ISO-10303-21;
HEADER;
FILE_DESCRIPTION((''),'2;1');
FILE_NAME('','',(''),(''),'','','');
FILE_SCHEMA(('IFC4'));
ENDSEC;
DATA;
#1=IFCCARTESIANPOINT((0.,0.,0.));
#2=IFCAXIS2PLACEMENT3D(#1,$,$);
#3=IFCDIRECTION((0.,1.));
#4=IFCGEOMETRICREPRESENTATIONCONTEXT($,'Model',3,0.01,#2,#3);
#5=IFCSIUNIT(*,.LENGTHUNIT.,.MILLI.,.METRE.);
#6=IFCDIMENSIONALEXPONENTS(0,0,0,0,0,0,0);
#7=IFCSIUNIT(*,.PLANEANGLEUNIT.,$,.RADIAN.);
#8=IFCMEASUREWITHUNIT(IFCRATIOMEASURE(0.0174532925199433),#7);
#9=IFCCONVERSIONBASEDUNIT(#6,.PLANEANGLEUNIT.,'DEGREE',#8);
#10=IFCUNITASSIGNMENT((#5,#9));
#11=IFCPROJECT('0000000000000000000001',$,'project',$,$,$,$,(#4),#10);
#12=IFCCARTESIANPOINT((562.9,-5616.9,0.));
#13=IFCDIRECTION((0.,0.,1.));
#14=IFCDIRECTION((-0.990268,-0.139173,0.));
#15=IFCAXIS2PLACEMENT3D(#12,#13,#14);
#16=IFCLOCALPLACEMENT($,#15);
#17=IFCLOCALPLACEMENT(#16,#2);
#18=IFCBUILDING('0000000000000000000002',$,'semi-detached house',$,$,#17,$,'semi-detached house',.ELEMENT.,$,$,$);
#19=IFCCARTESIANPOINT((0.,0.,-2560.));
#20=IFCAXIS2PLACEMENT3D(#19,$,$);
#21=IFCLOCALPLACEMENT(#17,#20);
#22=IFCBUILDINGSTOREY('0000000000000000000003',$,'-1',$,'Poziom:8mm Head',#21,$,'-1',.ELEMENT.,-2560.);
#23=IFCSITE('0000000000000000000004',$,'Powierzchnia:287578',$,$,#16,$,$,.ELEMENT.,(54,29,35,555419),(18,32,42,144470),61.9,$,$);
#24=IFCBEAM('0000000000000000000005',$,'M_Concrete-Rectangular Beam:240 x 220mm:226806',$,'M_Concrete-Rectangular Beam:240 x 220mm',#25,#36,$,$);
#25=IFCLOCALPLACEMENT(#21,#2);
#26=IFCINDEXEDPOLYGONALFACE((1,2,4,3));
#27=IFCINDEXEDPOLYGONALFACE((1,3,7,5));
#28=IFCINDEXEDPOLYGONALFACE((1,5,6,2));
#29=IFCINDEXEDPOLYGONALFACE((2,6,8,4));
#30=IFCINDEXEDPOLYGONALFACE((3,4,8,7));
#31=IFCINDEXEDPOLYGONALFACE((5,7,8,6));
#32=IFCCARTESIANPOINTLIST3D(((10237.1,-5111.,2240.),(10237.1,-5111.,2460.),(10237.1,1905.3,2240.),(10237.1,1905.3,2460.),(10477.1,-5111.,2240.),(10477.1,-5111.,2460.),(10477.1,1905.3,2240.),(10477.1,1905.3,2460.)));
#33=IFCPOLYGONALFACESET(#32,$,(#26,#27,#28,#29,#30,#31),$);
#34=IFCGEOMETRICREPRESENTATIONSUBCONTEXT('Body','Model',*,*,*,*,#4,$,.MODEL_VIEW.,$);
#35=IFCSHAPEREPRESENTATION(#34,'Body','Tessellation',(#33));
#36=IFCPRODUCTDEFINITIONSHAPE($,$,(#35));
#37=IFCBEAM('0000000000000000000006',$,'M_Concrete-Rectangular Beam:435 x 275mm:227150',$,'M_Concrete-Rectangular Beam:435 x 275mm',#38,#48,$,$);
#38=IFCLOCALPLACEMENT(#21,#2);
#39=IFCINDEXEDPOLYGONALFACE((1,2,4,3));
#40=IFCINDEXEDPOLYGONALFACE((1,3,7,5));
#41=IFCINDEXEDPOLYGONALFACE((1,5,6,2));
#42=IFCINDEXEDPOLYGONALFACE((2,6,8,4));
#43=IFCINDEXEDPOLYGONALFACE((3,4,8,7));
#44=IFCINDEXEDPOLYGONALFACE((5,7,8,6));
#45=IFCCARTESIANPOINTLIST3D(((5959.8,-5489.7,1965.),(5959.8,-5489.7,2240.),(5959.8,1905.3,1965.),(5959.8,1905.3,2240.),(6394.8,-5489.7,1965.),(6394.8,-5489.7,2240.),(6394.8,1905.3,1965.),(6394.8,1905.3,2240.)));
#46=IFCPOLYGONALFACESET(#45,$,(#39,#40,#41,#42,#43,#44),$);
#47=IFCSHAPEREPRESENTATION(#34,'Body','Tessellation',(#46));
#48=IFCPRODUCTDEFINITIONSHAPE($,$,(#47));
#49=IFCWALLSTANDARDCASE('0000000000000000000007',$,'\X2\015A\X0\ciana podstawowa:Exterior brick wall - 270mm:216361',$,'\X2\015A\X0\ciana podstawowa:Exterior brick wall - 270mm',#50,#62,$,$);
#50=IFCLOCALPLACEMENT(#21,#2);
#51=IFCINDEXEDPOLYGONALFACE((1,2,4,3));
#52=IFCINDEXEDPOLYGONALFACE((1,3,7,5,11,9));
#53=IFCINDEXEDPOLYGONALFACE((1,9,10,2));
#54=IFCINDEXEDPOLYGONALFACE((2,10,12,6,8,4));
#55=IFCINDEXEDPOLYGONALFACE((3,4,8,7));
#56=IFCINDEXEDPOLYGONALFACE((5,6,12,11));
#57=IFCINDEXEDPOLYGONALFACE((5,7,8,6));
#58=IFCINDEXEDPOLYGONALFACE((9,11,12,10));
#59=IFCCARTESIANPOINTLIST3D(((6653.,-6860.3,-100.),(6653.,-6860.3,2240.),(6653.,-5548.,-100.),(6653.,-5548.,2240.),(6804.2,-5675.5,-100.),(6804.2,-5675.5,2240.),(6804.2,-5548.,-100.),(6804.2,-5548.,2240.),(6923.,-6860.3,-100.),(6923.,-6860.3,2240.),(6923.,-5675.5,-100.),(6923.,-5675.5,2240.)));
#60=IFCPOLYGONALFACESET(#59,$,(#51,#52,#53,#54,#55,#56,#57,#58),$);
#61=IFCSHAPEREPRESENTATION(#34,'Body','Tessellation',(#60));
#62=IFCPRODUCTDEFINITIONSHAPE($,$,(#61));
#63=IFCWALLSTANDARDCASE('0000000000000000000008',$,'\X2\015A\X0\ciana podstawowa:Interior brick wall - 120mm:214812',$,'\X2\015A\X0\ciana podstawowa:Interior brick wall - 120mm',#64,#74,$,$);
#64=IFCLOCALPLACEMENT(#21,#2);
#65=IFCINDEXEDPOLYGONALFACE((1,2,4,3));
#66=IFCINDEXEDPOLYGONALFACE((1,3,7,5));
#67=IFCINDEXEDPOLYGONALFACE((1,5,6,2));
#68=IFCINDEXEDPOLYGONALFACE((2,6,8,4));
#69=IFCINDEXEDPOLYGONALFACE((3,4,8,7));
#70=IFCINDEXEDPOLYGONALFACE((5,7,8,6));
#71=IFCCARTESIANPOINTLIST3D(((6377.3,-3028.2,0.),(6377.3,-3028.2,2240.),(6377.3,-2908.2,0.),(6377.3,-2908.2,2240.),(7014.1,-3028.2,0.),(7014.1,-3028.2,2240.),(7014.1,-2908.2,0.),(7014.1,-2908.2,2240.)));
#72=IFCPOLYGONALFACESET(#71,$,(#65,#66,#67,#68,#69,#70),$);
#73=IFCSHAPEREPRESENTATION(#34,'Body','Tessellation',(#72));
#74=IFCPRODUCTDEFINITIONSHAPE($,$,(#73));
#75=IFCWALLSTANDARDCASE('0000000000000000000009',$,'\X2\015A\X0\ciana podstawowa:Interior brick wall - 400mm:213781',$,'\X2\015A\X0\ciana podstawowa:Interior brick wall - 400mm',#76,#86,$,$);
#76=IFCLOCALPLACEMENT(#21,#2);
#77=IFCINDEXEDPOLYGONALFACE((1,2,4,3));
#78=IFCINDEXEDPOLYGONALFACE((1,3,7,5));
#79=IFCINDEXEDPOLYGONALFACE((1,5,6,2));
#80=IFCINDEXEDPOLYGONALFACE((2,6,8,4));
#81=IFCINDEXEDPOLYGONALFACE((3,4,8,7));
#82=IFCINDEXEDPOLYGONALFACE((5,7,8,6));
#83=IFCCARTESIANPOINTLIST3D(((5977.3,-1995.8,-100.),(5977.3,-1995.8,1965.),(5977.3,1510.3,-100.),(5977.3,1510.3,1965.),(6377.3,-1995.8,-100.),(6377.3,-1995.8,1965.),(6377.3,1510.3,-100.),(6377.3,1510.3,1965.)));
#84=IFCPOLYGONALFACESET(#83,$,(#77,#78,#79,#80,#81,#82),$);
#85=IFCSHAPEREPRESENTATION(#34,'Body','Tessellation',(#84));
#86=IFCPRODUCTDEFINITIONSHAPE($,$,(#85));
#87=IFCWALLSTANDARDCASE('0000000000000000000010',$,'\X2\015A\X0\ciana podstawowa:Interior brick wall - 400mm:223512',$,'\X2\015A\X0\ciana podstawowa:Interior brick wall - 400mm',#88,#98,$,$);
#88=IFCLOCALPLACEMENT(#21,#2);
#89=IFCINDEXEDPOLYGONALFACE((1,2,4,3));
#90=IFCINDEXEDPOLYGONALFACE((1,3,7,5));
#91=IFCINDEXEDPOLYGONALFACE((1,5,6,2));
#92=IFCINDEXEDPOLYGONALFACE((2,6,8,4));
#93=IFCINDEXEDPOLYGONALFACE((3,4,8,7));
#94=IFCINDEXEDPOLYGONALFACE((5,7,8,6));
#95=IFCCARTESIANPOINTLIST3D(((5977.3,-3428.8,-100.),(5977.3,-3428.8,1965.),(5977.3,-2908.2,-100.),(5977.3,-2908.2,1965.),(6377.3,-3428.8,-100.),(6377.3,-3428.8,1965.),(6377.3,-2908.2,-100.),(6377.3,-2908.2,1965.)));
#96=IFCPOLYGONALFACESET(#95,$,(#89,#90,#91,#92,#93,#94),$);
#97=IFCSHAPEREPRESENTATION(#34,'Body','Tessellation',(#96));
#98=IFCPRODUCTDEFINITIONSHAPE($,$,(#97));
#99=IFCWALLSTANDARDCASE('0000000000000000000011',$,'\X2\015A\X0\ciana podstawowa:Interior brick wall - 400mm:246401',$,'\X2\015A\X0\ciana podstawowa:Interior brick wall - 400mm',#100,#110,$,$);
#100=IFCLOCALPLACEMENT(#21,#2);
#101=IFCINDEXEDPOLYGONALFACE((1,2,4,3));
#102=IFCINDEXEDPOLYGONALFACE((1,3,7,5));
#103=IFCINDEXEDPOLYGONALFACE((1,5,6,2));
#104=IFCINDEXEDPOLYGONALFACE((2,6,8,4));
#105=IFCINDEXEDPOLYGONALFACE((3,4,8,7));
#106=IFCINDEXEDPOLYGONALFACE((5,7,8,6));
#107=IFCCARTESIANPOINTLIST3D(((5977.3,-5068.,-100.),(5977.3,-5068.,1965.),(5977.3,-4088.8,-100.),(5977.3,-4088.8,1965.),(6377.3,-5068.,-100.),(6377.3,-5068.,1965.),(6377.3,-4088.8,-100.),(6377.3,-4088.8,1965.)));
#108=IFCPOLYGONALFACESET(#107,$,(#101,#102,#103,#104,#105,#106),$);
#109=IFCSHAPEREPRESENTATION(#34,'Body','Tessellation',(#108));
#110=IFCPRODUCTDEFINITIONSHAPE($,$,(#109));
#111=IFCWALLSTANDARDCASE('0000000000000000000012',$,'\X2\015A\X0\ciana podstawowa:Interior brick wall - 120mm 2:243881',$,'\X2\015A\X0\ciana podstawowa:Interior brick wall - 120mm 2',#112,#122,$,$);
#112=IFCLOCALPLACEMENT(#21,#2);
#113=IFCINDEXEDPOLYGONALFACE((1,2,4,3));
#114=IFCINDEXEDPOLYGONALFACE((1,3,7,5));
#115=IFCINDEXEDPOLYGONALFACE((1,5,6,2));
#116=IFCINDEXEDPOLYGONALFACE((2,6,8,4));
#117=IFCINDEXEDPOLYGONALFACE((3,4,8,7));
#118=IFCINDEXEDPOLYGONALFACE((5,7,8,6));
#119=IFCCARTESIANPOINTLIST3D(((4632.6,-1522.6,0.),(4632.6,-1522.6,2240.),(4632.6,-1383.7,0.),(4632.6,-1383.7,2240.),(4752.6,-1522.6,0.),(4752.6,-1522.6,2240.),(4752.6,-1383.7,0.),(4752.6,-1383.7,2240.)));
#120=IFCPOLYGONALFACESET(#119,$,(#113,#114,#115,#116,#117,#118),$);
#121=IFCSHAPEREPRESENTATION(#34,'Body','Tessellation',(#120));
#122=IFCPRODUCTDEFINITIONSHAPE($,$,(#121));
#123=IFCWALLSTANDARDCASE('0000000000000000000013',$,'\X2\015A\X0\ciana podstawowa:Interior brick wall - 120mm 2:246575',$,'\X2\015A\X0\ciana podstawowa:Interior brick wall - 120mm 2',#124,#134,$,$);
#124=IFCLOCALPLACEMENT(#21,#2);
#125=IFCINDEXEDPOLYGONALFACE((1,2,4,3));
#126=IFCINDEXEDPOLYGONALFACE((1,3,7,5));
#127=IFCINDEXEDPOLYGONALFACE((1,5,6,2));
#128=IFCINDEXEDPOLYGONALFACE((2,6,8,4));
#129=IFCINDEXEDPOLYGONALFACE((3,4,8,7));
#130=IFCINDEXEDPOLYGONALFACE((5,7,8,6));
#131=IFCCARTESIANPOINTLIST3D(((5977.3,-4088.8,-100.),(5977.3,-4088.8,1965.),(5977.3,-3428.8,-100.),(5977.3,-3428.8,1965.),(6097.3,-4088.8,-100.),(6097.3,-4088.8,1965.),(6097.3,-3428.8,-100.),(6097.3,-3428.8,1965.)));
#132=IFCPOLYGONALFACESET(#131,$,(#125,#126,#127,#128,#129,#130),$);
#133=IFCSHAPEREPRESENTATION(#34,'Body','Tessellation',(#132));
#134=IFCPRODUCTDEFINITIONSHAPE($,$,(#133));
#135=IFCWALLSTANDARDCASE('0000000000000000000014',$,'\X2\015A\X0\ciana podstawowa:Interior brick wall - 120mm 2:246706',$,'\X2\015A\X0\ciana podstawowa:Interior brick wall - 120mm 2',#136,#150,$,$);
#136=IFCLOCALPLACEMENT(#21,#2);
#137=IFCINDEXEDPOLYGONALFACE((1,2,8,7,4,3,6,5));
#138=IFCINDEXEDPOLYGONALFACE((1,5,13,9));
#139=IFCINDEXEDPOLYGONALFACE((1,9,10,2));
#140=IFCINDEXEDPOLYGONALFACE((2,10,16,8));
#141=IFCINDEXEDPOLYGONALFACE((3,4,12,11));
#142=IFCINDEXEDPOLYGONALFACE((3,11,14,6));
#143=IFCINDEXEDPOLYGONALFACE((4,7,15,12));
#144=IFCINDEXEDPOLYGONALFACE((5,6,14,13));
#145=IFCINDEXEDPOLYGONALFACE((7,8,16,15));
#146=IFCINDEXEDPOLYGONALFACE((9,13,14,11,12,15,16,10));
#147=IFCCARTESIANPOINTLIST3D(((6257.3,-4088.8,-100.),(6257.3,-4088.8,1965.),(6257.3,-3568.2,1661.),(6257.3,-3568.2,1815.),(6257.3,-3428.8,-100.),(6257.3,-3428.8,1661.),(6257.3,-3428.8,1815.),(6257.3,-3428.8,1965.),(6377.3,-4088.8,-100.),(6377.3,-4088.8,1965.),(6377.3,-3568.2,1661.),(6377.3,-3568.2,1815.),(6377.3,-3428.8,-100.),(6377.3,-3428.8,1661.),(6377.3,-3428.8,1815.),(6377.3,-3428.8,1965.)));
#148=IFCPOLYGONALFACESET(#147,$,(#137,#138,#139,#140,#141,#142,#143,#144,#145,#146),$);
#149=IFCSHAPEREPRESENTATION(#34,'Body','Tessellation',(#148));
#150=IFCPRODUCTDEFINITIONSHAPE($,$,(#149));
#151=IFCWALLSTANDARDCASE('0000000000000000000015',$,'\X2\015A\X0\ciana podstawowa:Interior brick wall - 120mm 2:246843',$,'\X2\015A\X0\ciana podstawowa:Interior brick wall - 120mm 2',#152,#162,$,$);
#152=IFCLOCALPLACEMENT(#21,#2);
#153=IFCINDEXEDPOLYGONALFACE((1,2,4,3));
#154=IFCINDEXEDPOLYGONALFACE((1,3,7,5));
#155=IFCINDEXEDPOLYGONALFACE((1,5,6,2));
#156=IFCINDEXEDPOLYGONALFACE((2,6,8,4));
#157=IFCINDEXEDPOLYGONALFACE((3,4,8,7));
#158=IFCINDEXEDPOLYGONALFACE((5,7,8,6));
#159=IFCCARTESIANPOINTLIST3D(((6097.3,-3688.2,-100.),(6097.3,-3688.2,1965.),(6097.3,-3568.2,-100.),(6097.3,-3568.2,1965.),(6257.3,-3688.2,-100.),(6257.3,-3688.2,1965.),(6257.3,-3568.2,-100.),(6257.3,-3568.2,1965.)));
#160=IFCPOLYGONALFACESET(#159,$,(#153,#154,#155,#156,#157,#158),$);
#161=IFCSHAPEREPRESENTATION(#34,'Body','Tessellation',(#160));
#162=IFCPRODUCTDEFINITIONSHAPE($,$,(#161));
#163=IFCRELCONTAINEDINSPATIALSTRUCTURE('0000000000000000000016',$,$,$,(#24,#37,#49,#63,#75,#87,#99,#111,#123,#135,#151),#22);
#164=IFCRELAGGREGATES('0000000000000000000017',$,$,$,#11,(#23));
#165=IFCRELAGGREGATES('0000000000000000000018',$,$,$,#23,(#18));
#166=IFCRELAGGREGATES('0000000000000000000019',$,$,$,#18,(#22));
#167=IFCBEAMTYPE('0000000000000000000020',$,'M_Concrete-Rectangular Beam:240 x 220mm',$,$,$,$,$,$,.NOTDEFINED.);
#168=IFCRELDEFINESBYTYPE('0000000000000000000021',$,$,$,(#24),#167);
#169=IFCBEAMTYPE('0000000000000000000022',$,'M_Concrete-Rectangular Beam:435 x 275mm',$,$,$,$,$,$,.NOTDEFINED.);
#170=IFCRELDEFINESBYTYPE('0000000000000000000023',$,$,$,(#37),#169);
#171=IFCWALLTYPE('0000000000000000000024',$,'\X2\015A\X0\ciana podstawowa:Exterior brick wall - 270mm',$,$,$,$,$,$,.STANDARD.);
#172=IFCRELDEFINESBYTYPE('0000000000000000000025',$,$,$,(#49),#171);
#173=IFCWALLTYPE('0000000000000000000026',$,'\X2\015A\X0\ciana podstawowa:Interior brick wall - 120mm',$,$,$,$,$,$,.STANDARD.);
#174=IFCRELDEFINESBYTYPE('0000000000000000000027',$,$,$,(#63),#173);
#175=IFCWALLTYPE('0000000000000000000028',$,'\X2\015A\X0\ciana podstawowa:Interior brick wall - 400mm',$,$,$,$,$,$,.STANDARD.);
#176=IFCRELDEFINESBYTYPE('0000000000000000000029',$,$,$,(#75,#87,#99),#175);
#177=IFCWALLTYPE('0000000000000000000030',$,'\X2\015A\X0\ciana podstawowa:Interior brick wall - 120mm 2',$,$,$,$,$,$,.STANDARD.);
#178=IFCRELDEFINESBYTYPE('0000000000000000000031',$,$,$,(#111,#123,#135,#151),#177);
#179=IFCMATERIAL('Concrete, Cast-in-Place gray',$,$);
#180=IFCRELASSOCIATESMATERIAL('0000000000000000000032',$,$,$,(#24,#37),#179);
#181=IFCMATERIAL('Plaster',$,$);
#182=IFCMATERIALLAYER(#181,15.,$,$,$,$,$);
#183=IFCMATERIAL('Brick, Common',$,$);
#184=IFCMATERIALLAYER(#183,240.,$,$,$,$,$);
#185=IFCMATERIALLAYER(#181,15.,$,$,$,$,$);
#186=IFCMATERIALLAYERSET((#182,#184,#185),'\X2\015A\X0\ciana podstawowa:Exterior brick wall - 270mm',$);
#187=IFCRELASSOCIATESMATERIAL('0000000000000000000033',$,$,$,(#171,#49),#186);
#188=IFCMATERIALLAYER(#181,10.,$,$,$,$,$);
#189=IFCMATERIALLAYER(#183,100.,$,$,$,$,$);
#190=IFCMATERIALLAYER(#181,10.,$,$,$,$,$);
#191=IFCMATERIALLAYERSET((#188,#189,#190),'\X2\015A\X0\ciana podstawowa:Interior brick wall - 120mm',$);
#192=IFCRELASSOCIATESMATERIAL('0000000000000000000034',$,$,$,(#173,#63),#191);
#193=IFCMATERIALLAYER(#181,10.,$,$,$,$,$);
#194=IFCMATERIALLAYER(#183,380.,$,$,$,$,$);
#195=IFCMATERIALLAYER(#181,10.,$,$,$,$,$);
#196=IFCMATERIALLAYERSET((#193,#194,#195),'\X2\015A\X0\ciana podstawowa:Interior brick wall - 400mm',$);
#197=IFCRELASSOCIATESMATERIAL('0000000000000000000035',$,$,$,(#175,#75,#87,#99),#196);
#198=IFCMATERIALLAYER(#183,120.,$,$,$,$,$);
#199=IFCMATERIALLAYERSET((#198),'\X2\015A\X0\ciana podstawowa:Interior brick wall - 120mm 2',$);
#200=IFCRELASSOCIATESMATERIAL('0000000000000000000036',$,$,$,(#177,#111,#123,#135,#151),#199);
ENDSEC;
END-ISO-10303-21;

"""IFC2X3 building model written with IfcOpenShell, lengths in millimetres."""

from ifc_helpers import new_model, entity, si_unit, converted_unit, direction, frame, frame_2d, origin, place, context, subcontext, project, spatial, polyline, rectangle, outline, extrude, clip, bounded_halfspace, material, layer, layer_set, layer_usage, type_object, element, save


model = new_model("IFC2X3")

# Units and contexts
model_context = context("Model", 3, precision=0.01, world=origin(), true_north=direction((0.0, 1.0)))
body_context = subcontext(model_context, "Body", "Model", "MODEL_VIEW")
ifc_project = project(units=[si_unit("LENGTHUNIT", "METRE", prefix="MILLI"), converted_unit("PLANEANGLEUNIT", "DEGREE", entity("IfcRatioMeasure", 0.0174532925199433), si_unit("PLANEANGLEUNIT", "RADIAN"), dimensions=[0, 0, 0, 0, 0, 0, 0])], contexts=[model_context])

# Site, building, storey
site_placement = place(None, frame((562.9, -5616.9, 0.0), z_axis=(0.0, 0.0, 1.0), x_axis=(-0.990268, -0.139173, 0.0)))
site = spatial("IfcSite", under=ifc_project, at=site_placement, Name="Powierzchnia:287578", CompositionType="ELEMENT", RefLatitude=(54, 29, 35, 555419), RefLongitude=(18, 32, 42, 144470), RefElevation=61.9)
building_placement = place(site_placement, origin())
building = spatial("IfcBuilding", under=site, at=building_placement, Name="semi-detached house", LongName="semi-detached house", CompositionType="ELEMENT")
storey_placement = place(building_placement, frame((0.0, 0.0, -2560.0)))
storey = spatial("IfcBuildingStorey", under=building, at=storey_placement, Name="-1", ObjectType="Poziom:8mm Head", LongName="-1", CompositionType="ELEMENT", Elevation=-2560.0)

# Beams
ifc_material_1 = material(Name="Concrete, Cast-in-Place gray")
beam_type_1 = type_object("IfcBeamType", Name="M_Concrete-Rectangular Beam:240 x 220mm", PredefinedType="NOTDEFINED")
beam_1_placement = place(storey_placement, frame((10357.1, 1905.3, 2460.0), z_axis=(0.0, 0.0, 1.0), x_axis=(0.0, -1.0, 0.0)))
element("IfcBeam", 1, at=beam_1_placement, inside=storey, type_object=beam_type_1, material=ifc_material_1, Name="M_Concrete-Rectangular Beam:240 x 220mm:226806", ObjectType="M_Concrete-Rectangular Beam:240 x 220mm", context=body_context, shape_type="SweptSolid", body=[
    extrude(rectangle(XDim=220.0, YDim=240.0, at=frame_2d((0.0, 0.0), x_axis=(1.0, 0.0))), frame((0.0, 0.0, -110.0), z_axis=(1.0, 0.0, 0.0), x_axis=(0.0, 0.0, -1.0)), (0.0, 0.0, 1.0), 7016.3),
])
beam_type_2 = type_object("IfcBeamType", Name="M_Concrete-Rectangular Beam:435 x 275mm", PredefinedType="NOTDEFINED")
beam_2_placement = place(storey_placement, frame((6177.3, 1905.3, 2240.0), z_axis=(0.0, 0.0, 1.0), x_axis=(0.0, -1.0, 0.0)))
element("IfcBeam", 2, at=beam_2_placement, inside=storey, type_object=beam_type_2, material=ifc_material_1, Name="M_Concrete-Rectangular Beam:435 x 275mm:227150", ObjectType="M_Concrete-Rectangular Beam:435 x 275mm", context=body_context, shape_type="SweptSolid", body=[
    extrude(rectangle(XDim=275.0, YDim=435.0, at=frame_2d((0.0, 0.0), x_axis=(1.0, 0.0))), frame((0.0, 0.0, -137.5), z_axis=(1.0, 0.0, 0.0), x_axis=(0.0, 0.0, -1.0)), (0.0, 0.0, 1.0), 7395.0),
])

# Walls
ifc_material_2 = material(Name="Plaster")
ifc_layer_1 = layer(ifc_material_2, 15.0)
ifc_material_3 = material(Name="Brick, Common")
ifc_layer_2 = layer(ifc_material_3, 240.0)
ifc_layer_3 = layer(ifc_material_2, 15.0)
ifc_layer_set_1 = layer_set([ifc_layer_1, ifc_layer_2, ifc_layer_3], Name="Ściana podstawowa:Exterior brick wall - 270mm")
ifc_layer_usage_1 = layer_usage(ifc_layer_set_1, "AXIS2", "POSITIVE", -135.0)
wall_type_1 = type_object("IfcWallType", Name="Ściana podstawowa:Exterior brick wall - 270mm", PredefinedType="STANDARD", material=ifc_layer_set_1)
wall_1_placement = place(storey_placement, frame((6788.0, -6860.3, -100.0), z_axis=(0.0, 0.0, 1.0), x_axis=(0.0, 1.0, 0.0)))
element("IfcWallStandardCase", 3, at=wall_1_placement, inside=storey, type_object=wall_type_1, material=ifc_layer_usage_1, Name="Ściana podstawowa:Exterior brick wall - 270mm:216361", ObjectType="Ściana podstawowa:Exterior brick wall - 270mm", context=body_context, shape_type="Clipping", body=[
    clip(extrude(outline(polyline([(1184.7, -135.0), (1184.7, -16.1), (1286.0, -16.1), (1312.2, -16.1), (1312.2, 135.0), (0.0, 135.0), (0.0, -135.0), (1184.7, -135.0)])), origin(), (0.0, 0.0, 1.0), 2340.0), bounded_halfspace(frame((0.0, -135.0, 2340.0), z_axis=(0.0, 0.0, -1.0), x_axis=(1.0, 0.0, 0.0)), True, frame((0.0, -135.0, 2340.0)), polyline([(0.0, 0.0), (1184.7, 0.0), (1184.7, 118.9), (1312.2, 118.9), (1312.2, 270.0), (0.0, 270.0), (0.0, 0.0)]))),
])
ifc_layer_4 = layer(ifc_material_2, 10.0)
ifc_layer_5 = layer(ifc_material_3, 100.0)
ifc_layer_6 = layer(ifc_material_2, 10.0)
ifc_layer_set_2 = layer_set([ifc_layer_4, ifc_layer_5, ifc_layer_6], Name="Ściana podstawowa:Interior brick wall - 120mm")
ifc_layer_usage_2 = layer_usage(ifc_layer_set_2, "AXIS2", "POSITIVE", -60.0)
wall_type_2 = type_object("IfcWallType", Name="Ściana podstawowa:Interior brick wall - 120mm", PredefinedType="STANDARD", material=ifc_layer_set_2)
wall_2_placement = place(storey_placement, frame((6377.3, -2968.2, 0.0)))
element("IfcWallStandardCase", 4, at=wall_2_placement, inside=storey, type_object=wall_type_2, material=ifc_layer_usage_2, Name="Ściana podstawowa:Interior brick wall - 120mm:214812", ObjectType="Ściana podstawowa:Interior brick wall - 120mm", context=body_context, shape_type="Clipping", body=[
    clip(extrude(rectangle(XDim=636.8, YDim=120.0, at=frame_2d((318.4, 0.0), x_axis=(-1.0, 0.0))), origin(), (0.0, 0.0, 1.0), 2240.0), bounded_halfspace(frame((636.8, -60.0, 0.0), z_axis=(0.0, 0.0, 1.0), x_axis=(0.0, 1.0, 0.0)), True, frame((636.8, -60.0, 0.0), z_axis=(0.0, 0.0, 1.0), x_axis=(0.0, 1.0, 0.0)), polyline([(0.0, 0.0), (120.0, 0.0), (120.0, 636.8), (0.0, 636.8), (0.0, 0.0)]))),
])
ifc_layer_7 = layer(ifc_material_2, 10.0)
ifc_layer_8 = layer(ifc_material_3, 380.0)
ifc_layer_9 = layer(ifc_material_2, 10.0)
ifc_layer_set_3 = layer_set([ifc_layer_7, ifc_layer_8, ifc_layer_9], Name="Ściana podstawowa:Interior brick wall - 400mm")
wall_type_3 = type_object("IfcWallType", Name="Ściana podstawowa:Interior brick wall - 400mm", PredefinedType="STANDARD", material=ifc_layer_set_3)
ifc_layer_usage_3 = layer_usage(ifc_layer_set_3, "AXIS2", "NEGATIVE", 200.0)
wall_3_placement = place(storey_placement, frame((6177.3, 1510.3, -100.0), z_axis=(0.0, 0.0, 1.0), x_axis=(0.0, -1.0, 0.0)))
element("IfcWallStandardCase", 5, at=wall_3_placement, inside=storey, type_object=wall_type_3, material=ifc_layer_usage_3, Name="Ściana podstawowa:Interior brick wall - 400mm:213781", ObjectType="Ściana podstawowa:Interior brick wall - 400mm", context=body_context, shape_type="SweptSolid", body=[
    extrude(rectangle(XDim=3506.1, YDim=400.0, at=frame_2d((1753.1, 0.0), x_axis=(-1.0, 0.0))), origin(), (0.0, 0.0, 1.0), 2065.0),
])
ifc_layer_usage_4 = layer_usage(ifc_layer_set_3, "AXIS2", "NEGATIVE", 200.0)
wall_4_placement = place(storey_placement, frame((6177.3, -2908.2, -100.0), z_axis=(0.0, 0.0, 1.0), x_axis=(0.0, -1.0, 0.0)))
element("IfcWallStandardCase", 6, at=wall_4_placement, inside=storey, type_object=wall_type_3, material=ifc_layer_usage_4, Name="Ściana podstawowa:Interior brick wall - 400mm:223512", ObjectType="Ściana podstawowa:Interior brick wall - 400mm", context=body_context, shape_type="SweptSolid", body=[
    extrude(rectangle(XDim=520.6, YDim=400.0, at=frame_2d((260.3, 0.0), x_axis=(-1.0, 0.0))), origin(), (0.0, 0.0, 1.0), 2065.0),
])
ifc_layer_usage_5 = layer_usage(ifc_layer_set_3, "AXIS2", "NEGATIVE", 200.0)
wall_5_placement = place(storey_placement, frame((6177.3, -4088.8, -100.0), z_axis=(0.0, 0.0, 1.0), x_axis=(0.0, -1.0, 0.0)))
element("IfcWallStandardCase", 7, at=wall_5_placement, inside=storey, type_object=wall_type_3, material=ifc_layer_usage_5, Name="Ściana podstawowa:Interior brick wall - 400mm:246401", ObjectType="Ściana podstawowa:Interior brick wall - 400mm", context=body_context, shape_type="SweptSolid", body=[
    extrude(rectangle(XDim=979.2, YDim=400.0, at=frame_2d((489.6, 0.0), x_axis=(-1.0, 0.0))), origin(), (0.0, 0.0, 1.0), 2065.0),
])
ifc_layer_10 = layer(ifc_material_3, 120.0)
ifc_layer_set_4 = layer_set([ifc_layer_10], Name="Ściana podstawowa:Interior brick wall - 120mm 2")
ifc_layer_usage_6 = layer_usage(ifc_layer_set_4, "AXIS2", "NEGATIVE", 60.0)
wall_type_4 = type_object("IfcWallType", Name="Ściana podstawowa:Interior brick wall - 120mm 2", PredefinedType="STANDARD", material=ifc_layer_set_4)
wall_6_placement = place(storey_placement, frame((4692.6, -1522.6, 0.0), z_axis=(0.0, 0.0, 1.0), x_axis=(0.0, 1.0, 0.0)))
element("IfcWallStandardCase", 8, at=wall_6_placement, inside=storey, type_object=wall_type_4, material=ifc_layer_usage_6, Name="Ściana podstawowa:Interior brick wall - 120mm 2:243881", ObjectType="Ściana podstawowa:Interior brick wall - 120mm 2", context=body_context, shape_type="Clipping", body=[
    clip(extrude(rectangle(XDim=138.9, YDim=120.0, at=frame_2d((69.5, 0.0), x_axis=(-1.0, 0.0))), origin(), (0.0, 0.0, 1.0), 2240.0), bounded_halfspace(frame((138.9, -60.0, 0.0)), True, frame((138.9, -60.0, 0.0)), polyline([(0.0, 0.0), (0.0, 120.0), (-138.9, 120.0), (-138.9, 0.0), (0.0, 0.0)]))),
])

# Wall
ifc_layer_usage_7 = layer_usage(ifc_layer_set_4, "AXIS2", "POSITIVE", -60.0)
wall_7_placement = place(storey_placement, frame((6037.3, -3428.8, -100.0), z_axis=(0.0, 0.0, 1.0), x_axis=(0.0, -1.0, 0.0)))
element("IfcWallStandardCase", 9, at=wall_7_placement, inside=storey, type_object=wall_type_4, material=ifc_layer_usage_7, Name="Ściana podstawowa:Interior brick wall - 120mm 2:246575", ObjectType="Ściana podstawowa:Interior brick wall - 120mm 2", context=body_context, shape_type="Clipping", body=[
    clip(extrude(rectangle(XDim=660.0, YDim=120.0, at=frame_2d((330.0, 0.0), x_axis=(-1.0, 0.0))), origin(), (0.0, 0.0, 1.0), 2065.0), bounded_halfspace(frame((0.0, -60.0, 2065.0), z_axis=(0.0, 0.0, 1.0), x_axis=(0.0, 1.0, 0.0)), False, frame((0.0, -60.0, 2065.0), z_axis=(0.0, 0.0, 1.0), x_axis=(0.0, 1.0, 0.0)), polyline([(0.0, 0.0), (0.0, -660.0), (120.0, -660.0), (120.0, -520.0), (120.0, -400.0), (120.0, -259.4), (120.0, -139.4), (120.0, 0.0), (0.0, 0.0)]))),
])

# Wall, opening
ifc_layer_usage_8 = layer_usage(ifc_layer_set_4, "AXIS2", "NEGATIVE", 60.0)
wall_8_placement = place(storey_placement, frame((6317.3, -3428.8, -100.0), z_axis=(0.0, 0.0, 1.0), x_axis=(0.0, -1.0, 0.0)))
wall_8 = element("IfcWallStandardCase", 10, at=wall_8_placement, inside=storey, type_object=wall_type_4, material=ifc_layer_usage_8, Name="Ściana podstawowa:Interior brick wall - 120mm 2:246706", ObjectType="Ściana podstawowa:Interior brick wall - 120mm 2", context=body_context, shape_type="Clipping", body=[
    clip(extrude(rectangle(XDim=660.0, YDim=120.0, at=frame_2d((330.0, 0.0), x_axis=(-1.0, 0.0))), origin(), (0.0, 0.0, 1.0), 2065.0), bounded_halfspace(frame((0.0, -60.0, 2065.0), z_axis=(0.0, 0.0, 1.0), x_axis=(0.0, 1.0, 0.0)), False, frame((0.0, -60.0, 2065.0), z_axis=(0.0, 0.0, 1.0), x_axis=(0.0, 1.0, 0.0)), polyline([(0.0, 0.0), (0.0, -139.4), (0.0, -259.4), (0.0, -400.0), (0.0, -520.0), (0.0, -660.0), (120.0, -660.0), (120.0, 0.0), (0.0, 0.0)]))),
])
opening_1_placement = place(wall_8_placement, origin())
element("IfcOpeningElement", 11, at=opening_1_placement, cuts=wall_8, ObjectType="Opening", context=body_context, shape_type="SweptSolid", body=[
    extrude(rectangle(XDim=154.0, YDim=139.4, at=frame_2d((-13.9, -12.6), x_axis=(0.0, 1.0))), frame((83.6, 60.0, 1850.6), z_axis=(0.0, -1.0, 0.0), x_axis=(1.0, 0.0, 0.0)), (0.0, 0.0, 1.0), 120.0),
])

# Wall
ifc_layer_usage_9 = layer_usage(ifc_layer_set_4, "AXIS2", "NEGATIVE", 60.0)
wall_9_placement = place(storey_placement, frame((6097.3, -3628.2, -100.0)))
element("IfcWallStandardCase", 12, at=wall_9_placement, inside=storey, type_object=wall_type_4, material=ifc_layer_usage_9, Name="Ściana podstawowa:Interior brick wall - 120mm 2:246843", ObjectType="Ściana podstawowa:Interior brick wall - 120mm 2", context=body_context, shape_type="Clipping", body=[
    clip(extrude(rectangle(XDim=160.0, YDim=120.0, at=frame_2d((80.0, 0.0), x_axis=(-1.0, 0.0))), origin(), (0.0, 0.0, 1.0), 2065.0), bounded_halfspace(frame((0.0, -60.0, 2065.0)), False, frame((0.0, -60.0, 2065.0)), polyline([(0.0, 0.0), (160.0, 0.0), (160.0, 120.0), (0.0, 120.0), (0.0, 0.0)]))),
])

save(model, "model.ifc")
